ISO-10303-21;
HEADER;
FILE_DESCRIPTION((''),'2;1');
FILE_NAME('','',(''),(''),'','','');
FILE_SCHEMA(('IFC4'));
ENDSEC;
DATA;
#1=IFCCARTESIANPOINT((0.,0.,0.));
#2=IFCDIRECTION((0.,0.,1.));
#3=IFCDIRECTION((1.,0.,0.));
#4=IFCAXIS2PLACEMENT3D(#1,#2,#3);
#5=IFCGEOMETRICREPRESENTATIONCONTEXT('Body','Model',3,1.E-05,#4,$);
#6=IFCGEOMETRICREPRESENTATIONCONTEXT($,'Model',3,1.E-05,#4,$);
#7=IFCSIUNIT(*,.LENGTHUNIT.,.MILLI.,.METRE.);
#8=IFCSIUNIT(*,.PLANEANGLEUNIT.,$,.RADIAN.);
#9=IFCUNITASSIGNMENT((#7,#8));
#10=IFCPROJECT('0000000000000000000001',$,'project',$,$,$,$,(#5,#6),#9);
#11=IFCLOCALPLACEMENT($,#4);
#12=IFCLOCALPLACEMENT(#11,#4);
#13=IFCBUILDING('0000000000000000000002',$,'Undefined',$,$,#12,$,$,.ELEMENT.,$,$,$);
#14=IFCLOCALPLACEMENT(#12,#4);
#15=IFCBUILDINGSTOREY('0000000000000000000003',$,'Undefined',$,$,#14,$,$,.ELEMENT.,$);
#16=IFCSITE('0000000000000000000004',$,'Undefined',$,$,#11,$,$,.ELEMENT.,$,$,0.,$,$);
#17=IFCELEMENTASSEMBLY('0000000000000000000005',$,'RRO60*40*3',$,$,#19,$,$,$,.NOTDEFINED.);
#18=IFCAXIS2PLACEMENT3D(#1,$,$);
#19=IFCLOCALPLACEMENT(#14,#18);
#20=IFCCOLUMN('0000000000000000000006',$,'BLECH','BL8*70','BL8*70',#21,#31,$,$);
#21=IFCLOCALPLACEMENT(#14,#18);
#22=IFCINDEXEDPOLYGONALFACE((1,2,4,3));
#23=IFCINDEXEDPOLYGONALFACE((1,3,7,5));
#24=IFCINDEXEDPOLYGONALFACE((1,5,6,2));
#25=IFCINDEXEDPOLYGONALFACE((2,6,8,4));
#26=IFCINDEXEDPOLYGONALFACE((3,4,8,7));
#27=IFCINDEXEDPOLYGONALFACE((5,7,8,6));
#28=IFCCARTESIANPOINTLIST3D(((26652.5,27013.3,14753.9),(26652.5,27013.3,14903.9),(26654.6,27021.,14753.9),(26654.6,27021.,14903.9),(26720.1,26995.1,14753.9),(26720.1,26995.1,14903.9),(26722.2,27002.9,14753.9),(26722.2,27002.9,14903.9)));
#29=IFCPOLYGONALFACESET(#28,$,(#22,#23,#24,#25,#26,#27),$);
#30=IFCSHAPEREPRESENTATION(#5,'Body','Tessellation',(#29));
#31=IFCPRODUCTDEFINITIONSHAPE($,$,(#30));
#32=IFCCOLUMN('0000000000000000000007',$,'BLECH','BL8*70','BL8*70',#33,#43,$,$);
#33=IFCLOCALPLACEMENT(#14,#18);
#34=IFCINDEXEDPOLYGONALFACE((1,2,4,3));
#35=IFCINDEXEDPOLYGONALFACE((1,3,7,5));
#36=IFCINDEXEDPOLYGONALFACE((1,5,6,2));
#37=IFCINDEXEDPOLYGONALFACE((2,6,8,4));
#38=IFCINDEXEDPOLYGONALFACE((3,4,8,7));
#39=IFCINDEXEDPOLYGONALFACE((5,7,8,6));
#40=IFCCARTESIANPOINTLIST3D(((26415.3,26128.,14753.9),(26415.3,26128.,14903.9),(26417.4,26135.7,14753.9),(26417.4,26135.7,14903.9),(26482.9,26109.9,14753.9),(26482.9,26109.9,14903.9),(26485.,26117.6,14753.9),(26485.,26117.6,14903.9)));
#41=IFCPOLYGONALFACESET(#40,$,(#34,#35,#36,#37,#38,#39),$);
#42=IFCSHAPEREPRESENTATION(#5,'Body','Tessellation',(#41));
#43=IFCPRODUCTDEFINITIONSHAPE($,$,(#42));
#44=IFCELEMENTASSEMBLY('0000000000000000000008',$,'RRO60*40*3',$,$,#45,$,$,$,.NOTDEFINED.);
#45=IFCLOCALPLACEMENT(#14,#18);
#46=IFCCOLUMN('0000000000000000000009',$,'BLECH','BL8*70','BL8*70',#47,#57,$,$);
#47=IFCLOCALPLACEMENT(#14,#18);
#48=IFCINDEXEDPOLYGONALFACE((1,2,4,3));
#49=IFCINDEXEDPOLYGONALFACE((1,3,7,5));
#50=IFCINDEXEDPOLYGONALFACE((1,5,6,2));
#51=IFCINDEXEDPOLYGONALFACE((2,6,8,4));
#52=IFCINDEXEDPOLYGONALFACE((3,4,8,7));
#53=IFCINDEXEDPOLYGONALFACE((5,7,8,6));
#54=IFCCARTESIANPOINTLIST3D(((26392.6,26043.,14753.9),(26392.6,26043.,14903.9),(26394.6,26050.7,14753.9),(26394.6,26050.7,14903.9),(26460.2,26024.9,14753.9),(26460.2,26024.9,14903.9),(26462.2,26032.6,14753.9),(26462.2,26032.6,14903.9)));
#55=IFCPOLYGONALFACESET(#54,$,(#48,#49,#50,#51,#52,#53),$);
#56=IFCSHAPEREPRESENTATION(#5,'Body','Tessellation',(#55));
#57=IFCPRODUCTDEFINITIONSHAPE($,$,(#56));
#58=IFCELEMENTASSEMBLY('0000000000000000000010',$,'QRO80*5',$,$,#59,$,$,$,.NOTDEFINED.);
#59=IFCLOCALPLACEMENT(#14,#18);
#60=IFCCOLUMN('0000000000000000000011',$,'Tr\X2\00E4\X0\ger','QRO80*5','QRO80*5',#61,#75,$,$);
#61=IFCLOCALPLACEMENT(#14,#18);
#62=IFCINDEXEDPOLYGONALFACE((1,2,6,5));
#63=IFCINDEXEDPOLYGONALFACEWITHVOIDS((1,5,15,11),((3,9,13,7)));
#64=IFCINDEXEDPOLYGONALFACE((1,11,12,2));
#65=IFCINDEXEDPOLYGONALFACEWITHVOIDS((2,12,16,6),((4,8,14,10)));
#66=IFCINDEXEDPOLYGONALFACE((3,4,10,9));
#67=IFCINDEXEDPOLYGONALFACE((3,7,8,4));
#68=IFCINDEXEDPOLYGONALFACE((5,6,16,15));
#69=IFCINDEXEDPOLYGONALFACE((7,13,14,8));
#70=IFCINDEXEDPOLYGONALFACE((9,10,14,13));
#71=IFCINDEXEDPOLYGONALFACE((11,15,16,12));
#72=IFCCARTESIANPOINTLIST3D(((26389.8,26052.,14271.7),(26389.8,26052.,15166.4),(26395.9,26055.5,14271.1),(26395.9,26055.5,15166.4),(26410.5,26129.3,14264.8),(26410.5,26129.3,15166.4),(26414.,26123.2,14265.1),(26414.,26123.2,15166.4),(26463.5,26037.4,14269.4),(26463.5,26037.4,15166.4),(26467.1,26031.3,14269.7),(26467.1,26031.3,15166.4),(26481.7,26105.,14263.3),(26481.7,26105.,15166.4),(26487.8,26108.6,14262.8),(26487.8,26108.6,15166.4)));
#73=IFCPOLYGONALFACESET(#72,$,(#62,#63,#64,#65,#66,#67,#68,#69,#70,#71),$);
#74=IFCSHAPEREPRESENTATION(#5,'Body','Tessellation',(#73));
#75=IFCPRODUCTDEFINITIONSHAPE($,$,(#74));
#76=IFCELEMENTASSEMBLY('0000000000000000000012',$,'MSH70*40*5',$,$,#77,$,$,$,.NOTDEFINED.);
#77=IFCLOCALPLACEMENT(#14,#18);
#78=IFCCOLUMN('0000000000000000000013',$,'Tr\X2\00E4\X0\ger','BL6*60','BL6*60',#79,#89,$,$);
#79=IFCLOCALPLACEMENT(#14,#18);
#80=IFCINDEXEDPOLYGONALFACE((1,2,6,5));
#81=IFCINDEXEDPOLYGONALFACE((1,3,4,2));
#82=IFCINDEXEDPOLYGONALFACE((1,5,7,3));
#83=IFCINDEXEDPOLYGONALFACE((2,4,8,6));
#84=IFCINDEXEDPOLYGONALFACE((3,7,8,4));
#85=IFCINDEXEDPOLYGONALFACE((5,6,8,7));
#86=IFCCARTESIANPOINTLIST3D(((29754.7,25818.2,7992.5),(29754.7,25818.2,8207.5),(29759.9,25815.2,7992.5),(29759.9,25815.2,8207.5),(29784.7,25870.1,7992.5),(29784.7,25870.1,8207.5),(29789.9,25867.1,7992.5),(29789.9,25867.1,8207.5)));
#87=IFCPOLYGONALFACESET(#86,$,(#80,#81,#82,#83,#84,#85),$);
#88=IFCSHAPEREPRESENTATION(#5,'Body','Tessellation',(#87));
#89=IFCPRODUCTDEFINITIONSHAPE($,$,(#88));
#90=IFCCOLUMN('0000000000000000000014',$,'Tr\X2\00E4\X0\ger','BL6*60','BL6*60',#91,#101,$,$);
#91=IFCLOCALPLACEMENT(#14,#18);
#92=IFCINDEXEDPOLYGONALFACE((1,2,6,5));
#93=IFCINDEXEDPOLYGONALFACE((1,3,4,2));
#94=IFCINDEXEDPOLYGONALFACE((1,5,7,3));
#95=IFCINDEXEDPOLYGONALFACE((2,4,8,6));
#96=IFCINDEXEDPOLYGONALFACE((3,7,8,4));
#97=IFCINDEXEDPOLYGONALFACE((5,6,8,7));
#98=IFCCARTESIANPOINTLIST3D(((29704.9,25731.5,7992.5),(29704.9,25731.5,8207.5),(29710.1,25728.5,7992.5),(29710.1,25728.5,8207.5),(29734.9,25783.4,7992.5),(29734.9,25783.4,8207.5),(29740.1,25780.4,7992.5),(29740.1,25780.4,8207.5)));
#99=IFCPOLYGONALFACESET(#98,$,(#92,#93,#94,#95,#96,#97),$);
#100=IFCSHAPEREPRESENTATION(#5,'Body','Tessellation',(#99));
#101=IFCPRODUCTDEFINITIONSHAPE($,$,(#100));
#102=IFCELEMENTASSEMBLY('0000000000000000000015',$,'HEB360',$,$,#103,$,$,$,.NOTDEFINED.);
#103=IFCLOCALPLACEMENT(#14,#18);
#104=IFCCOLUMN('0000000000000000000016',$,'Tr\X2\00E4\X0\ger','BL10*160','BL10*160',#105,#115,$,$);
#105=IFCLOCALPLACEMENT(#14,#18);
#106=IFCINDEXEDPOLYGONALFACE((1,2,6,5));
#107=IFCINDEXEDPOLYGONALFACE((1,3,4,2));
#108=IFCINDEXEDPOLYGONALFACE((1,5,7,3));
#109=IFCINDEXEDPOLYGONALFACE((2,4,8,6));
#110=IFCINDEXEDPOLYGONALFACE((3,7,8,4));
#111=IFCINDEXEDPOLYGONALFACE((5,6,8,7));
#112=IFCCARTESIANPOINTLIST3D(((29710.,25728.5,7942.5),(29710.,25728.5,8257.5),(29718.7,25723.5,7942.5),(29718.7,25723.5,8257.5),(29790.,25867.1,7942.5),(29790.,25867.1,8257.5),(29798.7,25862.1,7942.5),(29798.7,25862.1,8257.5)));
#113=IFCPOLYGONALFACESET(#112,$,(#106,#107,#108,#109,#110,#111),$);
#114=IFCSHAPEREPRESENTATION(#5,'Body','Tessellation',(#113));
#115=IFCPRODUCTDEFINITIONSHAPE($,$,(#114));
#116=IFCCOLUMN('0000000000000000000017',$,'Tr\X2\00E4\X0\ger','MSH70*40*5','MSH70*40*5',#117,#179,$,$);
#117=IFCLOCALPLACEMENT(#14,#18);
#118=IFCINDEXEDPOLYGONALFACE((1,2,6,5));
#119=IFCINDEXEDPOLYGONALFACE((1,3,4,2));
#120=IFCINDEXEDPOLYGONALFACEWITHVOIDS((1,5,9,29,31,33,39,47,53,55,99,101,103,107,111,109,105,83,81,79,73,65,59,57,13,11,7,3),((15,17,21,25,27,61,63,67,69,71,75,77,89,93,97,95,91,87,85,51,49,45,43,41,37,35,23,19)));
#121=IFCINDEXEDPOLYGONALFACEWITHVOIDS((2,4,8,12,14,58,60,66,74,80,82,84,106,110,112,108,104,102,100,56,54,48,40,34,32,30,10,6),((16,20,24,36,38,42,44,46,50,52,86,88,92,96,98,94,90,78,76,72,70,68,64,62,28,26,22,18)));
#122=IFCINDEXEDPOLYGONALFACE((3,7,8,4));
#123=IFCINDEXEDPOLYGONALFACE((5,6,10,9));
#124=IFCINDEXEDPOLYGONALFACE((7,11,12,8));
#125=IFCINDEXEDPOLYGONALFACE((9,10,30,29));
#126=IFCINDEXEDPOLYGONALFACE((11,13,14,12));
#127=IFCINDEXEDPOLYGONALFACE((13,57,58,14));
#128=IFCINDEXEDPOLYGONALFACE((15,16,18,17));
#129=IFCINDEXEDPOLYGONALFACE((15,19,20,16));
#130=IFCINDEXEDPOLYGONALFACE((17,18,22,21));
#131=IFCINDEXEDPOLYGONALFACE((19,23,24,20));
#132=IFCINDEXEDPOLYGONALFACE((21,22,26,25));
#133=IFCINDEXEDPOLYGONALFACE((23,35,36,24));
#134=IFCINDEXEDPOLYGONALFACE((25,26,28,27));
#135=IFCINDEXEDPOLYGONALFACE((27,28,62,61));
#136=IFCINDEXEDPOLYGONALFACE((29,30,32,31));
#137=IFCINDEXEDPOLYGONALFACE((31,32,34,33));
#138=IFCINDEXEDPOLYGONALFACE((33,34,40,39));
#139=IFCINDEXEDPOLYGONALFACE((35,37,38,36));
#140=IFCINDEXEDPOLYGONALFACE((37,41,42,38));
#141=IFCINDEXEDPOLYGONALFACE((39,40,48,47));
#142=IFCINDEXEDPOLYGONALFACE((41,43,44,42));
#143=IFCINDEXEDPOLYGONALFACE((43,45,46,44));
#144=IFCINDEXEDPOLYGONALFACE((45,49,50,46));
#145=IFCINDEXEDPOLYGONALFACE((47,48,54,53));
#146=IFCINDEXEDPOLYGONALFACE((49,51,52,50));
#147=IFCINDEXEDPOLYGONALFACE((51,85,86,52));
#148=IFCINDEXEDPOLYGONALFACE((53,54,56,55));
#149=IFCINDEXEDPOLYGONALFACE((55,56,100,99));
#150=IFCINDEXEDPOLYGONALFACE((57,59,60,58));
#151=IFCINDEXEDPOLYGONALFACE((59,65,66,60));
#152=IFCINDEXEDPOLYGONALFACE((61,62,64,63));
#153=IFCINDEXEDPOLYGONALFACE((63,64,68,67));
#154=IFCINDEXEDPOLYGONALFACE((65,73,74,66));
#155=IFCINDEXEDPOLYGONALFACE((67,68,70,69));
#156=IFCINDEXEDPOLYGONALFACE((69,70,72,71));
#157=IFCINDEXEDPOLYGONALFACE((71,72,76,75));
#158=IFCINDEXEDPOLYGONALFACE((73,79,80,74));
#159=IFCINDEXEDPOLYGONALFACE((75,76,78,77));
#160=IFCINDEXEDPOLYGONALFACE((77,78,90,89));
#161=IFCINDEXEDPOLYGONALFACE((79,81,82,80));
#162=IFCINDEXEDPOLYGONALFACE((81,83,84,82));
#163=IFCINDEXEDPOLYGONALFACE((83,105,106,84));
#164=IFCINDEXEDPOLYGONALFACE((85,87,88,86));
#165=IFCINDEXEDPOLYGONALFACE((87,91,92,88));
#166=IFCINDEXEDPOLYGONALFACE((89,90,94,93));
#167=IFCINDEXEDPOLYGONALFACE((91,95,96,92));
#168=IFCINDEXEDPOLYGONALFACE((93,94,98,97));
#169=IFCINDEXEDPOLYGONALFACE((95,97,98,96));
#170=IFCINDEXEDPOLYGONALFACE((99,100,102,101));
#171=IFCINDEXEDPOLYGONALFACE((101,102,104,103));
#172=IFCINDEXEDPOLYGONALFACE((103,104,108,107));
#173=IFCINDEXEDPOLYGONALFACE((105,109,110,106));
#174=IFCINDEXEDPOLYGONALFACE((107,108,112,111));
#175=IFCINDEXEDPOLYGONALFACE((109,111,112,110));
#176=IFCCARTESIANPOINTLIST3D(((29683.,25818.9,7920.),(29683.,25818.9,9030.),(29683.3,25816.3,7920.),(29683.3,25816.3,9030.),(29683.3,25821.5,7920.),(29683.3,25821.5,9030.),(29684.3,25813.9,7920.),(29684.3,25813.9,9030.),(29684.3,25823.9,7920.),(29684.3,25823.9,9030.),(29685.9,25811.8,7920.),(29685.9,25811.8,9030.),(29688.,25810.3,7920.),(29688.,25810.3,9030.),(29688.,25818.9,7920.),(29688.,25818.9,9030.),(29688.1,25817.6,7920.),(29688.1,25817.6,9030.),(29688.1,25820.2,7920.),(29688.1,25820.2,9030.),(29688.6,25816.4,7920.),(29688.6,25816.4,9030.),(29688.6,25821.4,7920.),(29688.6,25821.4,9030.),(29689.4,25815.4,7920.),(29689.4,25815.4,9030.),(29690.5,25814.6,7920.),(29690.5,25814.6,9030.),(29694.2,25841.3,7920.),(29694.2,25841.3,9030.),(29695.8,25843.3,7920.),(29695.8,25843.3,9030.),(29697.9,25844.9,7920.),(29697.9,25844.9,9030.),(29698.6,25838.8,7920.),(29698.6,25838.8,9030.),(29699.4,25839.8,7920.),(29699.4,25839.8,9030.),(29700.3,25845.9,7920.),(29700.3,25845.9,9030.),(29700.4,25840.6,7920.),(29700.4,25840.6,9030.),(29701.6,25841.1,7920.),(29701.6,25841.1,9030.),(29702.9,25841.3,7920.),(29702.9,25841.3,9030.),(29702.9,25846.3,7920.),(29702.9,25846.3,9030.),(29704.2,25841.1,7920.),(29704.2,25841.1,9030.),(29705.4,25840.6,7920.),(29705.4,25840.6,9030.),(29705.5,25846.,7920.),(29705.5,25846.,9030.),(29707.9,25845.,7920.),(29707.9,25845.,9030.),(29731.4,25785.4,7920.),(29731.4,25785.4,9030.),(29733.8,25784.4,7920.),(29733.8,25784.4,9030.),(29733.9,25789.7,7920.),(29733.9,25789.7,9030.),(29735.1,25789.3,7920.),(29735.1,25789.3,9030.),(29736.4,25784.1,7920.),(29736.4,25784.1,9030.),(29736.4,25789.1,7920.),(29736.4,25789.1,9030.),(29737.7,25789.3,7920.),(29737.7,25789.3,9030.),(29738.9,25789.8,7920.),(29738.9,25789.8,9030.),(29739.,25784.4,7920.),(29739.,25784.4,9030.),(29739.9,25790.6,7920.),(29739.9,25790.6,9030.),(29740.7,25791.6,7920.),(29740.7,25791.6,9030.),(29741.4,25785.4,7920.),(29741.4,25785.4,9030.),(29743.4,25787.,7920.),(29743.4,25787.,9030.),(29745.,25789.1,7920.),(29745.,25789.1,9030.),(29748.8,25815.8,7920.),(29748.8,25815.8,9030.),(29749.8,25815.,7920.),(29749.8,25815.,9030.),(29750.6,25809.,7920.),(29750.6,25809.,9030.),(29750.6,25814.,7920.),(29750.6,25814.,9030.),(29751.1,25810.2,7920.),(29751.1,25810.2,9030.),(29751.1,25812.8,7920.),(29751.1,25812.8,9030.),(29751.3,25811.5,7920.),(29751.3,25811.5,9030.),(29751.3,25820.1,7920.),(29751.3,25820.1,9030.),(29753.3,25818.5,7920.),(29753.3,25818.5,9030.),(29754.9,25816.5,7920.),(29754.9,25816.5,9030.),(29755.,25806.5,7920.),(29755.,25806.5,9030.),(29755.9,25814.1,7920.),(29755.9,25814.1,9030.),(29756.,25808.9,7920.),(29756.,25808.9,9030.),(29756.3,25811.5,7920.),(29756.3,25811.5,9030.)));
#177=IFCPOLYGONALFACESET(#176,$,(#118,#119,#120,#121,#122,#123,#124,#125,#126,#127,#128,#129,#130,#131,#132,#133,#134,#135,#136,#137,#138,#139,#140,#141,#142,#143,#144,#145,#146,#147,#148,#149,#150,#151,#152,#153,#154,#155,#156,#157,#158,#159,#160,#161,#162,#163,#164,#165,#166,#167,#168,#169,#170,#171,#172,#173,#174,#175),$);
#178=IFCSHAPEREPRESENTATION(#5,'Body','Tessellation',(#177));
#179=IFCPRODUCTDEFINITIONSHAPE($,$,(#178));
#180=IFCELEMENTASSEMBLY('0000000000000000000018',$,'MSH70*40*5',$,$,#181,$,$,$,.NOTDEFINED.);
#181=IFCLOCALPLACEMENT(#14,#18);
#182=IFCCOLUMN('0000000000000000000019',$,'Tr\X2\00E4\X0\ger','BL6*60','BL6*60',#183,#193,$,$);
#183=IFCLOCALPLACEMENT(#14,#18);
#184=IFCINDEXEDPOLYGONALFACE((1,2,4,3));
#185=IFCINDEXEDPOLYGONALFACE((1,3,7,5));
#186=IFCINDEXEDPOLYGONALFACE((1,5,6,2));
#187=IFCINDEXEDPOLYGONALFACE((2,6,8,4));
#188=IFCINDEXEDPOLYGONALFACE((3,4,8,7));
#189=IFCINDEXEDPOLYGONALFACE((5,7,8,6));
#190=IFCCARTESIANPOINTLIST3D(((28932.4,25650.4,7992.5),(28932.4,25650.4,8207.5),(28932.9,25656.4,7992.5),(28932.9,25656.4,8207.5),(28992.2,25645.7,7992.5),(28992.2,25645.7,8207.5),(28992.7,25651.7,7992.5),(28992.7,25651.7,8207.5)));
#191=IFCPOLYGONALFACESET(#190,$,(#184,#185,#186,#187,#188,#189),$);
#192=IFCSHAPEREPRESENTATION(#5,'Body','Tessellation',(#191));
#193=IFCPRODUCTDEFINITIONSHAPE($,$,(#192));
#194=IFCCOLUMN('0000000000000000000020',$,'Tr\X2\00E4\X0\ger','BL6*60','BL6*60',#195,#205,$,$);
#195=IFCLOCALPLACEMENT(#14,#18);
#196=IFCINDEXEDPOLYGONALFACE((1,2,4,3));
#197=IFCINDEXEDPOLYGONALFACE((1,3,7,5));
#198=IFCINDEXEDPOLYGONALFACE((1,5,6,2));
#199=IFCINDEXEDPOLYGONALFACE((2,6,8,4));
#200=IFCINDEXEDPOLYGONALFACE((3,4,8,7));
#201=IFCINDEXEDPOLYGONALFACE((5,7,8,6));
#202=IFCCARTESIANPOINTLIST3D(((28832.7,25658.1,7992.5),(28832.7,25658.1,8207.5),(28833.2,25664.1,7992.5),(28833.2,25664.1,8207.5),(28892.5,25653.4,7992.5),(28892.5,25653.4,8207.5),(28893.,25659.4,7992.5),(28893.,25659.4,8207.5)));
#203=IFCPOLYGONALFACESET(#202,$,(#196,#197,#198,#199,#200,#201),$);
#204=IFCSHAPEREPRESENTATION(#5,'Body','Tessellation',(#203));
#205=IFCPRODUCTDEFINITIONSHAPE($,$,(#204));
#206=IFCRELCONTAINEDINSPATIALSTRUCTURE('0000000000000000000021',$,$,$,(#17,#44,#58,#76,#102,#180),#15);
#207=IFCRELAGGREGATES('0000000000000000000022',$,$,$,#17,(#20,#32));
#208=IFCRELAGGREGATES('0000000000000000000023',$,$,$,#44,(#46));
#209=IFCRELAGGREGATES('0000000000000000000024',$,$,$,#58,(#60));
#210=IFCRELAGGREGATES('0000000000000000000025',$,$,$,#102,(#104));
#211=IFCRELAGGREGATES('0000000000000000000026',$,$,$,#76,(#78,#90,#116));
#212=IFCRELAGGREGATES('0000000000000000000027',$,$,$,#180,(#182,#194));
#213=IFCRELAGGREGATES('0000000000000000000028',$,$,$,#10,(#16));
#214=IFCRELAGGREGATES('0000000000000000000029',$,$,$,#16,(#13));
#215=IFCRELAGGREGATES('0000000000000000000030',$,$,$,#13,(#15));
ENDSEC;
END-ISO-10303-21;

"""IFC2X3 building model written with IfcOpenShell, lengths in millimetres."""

from ifc_helpers import new_model, si_unit, frame, origin_with_axes, origin_2d_with_axis, place, context, project, spatial, rectangle, hollow_rectangle, extrude, clip, halfspace, element, aggregate, save


model = new_model("IFC2X3")

# Units and contexts
model_context_1 = context("Model", 3, precision=1e-05, world=origin_with_axes(), identifier="Body")
model_context_2 = context("Model", 3, precision=1e-05, world=origin_with_axes())
ifc_project = project(units=[si_unit("LENGTHUNIT", "METRE", prefix="MILLI"), si_unit("PLANEANGLEUNIT", "RADIAN")], contexts=[model_context_1, model_context_2])

# Site, building, storey
site_placement = place(None, origin_with_axes())
site = spatial("IfcSite", under=ifc_project, at=site_placement, Name="Undefined", CompositionType="ELEMENT", RefElevation=0.0)
building_placement = place(site_placement, origin_with_axes())
building = spatial("IfcBuilding", under=site, at=building_placement, Name="Undefined", CompositionType="ELEMENT")
storey_placement = place(building_placement, origin_with_axes())
storey = spatial("IfcBuildingStorey", under=building, at=storey_placement, Name="Undefined", CompositionType="ELEMENT")

# Element assembly, columns
assembly_1 = element("IfcElementAssembly", 1, inside=storey, Name="RRO60*40*3", PredefinedType="NOTDEFINED")
column_1_placement = place(storey_placement, frame((26687.4, 27008.1, 14753.9), z_axis=(0.0, 0.0, 1.0), x_axis=(1.0, 0.0, 0.0)))
column_1 = element("IfcColumn", 2, at=column_1_placement, Name="BLECH", Description="BL8*70", ObjectType="BL8*70", context=model_context_1, shape_type="SweptSolid", body=[
    extrude(rectangle(XDim=8.0, YDim=70.0, at=origin_2d_with_axis()), frame((0.0, 0.0, 150.0), z_axis=(0.0, 0.0, -1.0), x_axis=(-0.258815, -0.965927, -0.000003)), (0.0, 0.0, 1.0), 150.0),
])
column_2_placement = place(storey_placement, frame((26450.2, 26122.8, 14753.9), z_axis=(0.0, 0.0, 1.0), x_axis=(1.0, 0.0, 0.0)))
column_2 = element("IfcColumn", 3, at=column_2_placement, Name="BLECH", Description="BL8*70", ObjectType="BL8*70", context=model_context_1, shape_type="SweptSolid", body=[
    extrude(rectangle(XDim=8.0, YDim=70.0, at=origin_2d_with_axis()), frame((0.0, 0.0, 150.0), z_axis=(0.0, 0.0, -1.0), x_axis=(0.258815, 0.965927, 0.000003)), (0.0, 0.0, 1.0), 150.0),
])
aggregate(assembly_1, [column_1, column_2])

# Element assemblies, columns
assembly_2 = element("IfcElementAssembly", 4, inside=storey, Name="RRO60*40*3", PredefinedType="NOTDEFINED")
column_3_placement = place(storey_placement, frame((26427.4, 26037.8, 14753.9), z_axis=(0.0, 0.0, 1.0), x_axis=(1.0, 0.0, 0.0)))
column_3 = element("IfcColumn", 5, at=column_3_placement, Name="BLECH", Description="BL8*70", ObjectType="BL8*70", context=model_context_1, shape_type="SweptSolid", body=[
    extrude(rectangle(XDim=8.0, YDim=70.0, at=origin_2d_with_axis()), frame((0.0, 0.0, 150.0), z_axis=(0.0, 0.0, -1.0), x_axis=(-0.258815, -0.965927, -0.000003)), (0.0, 0.0, 1.0), 150.0),
])
aggregate(assembly_2, [column_3])
assembly_3 = element("IfcElementAssembly", 6, inside=storey, Name="QRO80*5", PredefinedType="NOTDEFINED")
column_4_placement = place(storey_placement, frame((26438.8, 26080.3, 14404.4), z_axis=(0.0, 0.0, 1.0), x_axis=(1.0, 0.0, 0.0)))
column_4 = element("IfcColumn", 7, at=column_4_placement, Name="Träger", Description="QRO80*5", ObjectType="QRO80*5", context=model_context_1, shape_type="Clipping", body=[
    clip(clip(extrude(hollow_rectangle(XDim=80.0, YDim=80.0, WallThickness=5.0, at=origin_2d_with_axis()), frame((0.0, 0.0, 762.0), z_axis=(0.0, 0.0, -1.0), x_axis=(-0.258926, -0.965897, -0.000005)), (0.0, 0.0, 1.0), 903.6), halfspace(frame((38.6, -10.4, -138.1), z_axis=(0.046071, 0.076365, 0.996015), x_axis=(-0.255919, -0.962895, 0.085663)), True)), halfspace(frame((-38.6, 10.4, 762.0), z_axis=(0.0, 0.0, -1.0), x_axis=(-0.258815, -0.965927, -0.000003)), True)),
])
aggregate(assembly_3, [column_4])

# Element assembly, columns
assembly_4 = element("IfcElementAssembly", 8, inside=storey, Name="MSH70*40*5", PredefinedType="NOTDEFINED")
column_5_placement = place(storey_placement, frame((29772.3, 25842.6, 7992.5), z_axis=(0.0, 0.0, 1.0), x_axis=(1.0, 0.0, 0.0)))
column_5 = element("IfcColumn", 9, at=column_5_placement, Name="Träger", Description="BL6*60", ObjectType="BL6*60", context=model_context_1, shape_type="SweptSolid", body=[
    extrude(rectangle(XDim=6.0, YDim=60.0, at=origin_2d_with_axis()), frame((0.0, 0.0, 215.0), z_axis=(0.0, 0.0, -1.0), x_axis=(-0.866025, 0.500001, 0.0)), (0.0, 0.0, 1.0), 215.0),
])
column_6_placement = place(storey_placement, frame((29722.5, 25756.0, 7992.5), z_axis=(0.0, 0.0, 1.0), x_axis=(1.0, 0.0, 0.0)))
column_6 = element("IfcColumn", 10, at=column_6_placement, Name="Träger", Description="BL6*60", ObjectType="BL6*60", context=model_context_1, shape_type="SweptSolid", body=[
    extrude(rectangle(XDim=6.0, YDim=60.0, at=origin_2d_with_axis()), frame((0.0, 0.0, 215.0), z_axis=(0.0, 0.0, -1.0), x_axis=(-0.866025, 0.500001, 0.0)), (0.0, 0.0, 1.0), 215.0),
])

# Element assembly, column
assembly_5 = element("IfcElementAssembly", 11, inside=storey, Name="HEB360", PredefinedType="NOTDEFINED")
column_7_placement = place(storey_placement, frame((29754.3, 25795.3, 7942.5), z_axis=(0.0, 0.0, 1.0), x_axis=(1.0, 0.0, 0.0)))
column_7 = element("IfcColumn", 12, at=column_7_placement, Name="Träger", Description="BL10*160", ObjectType="BL10*160", context=model_context_1, shape_type="SweptSolid", body=[
    extrude(rectangle(XDim=10.0, YDim=160.0, at=origin_2d_with_axis()), frame((0.0, 0.0, 315.0), z_axis=(0.0, 0.0, -1.0), x_axis=(-0.866025, 0.500001, 0.0)), (0.0, 0.0, 1.0), 315.0),
])
aggregate(assembly_5, [column_7])

# Column
column_8_placement = place(storey_placement, frame((29719.6, 25815.2, 7920.0), z_axis=(0.0, 0.0, 1.0), x_axis=(1.0, 0.0, 0.0)))
column_8 = element("IfcColumn", 13, at=column_8_placement, Name="Träger", Description="MSH70*40*5", ObjectType="MSH70*40*5", context=model_context_1, shape_type="SweptSolid", body=[
    extrude(hollow_rectangle(XDim=40.0, YDim=70.0, WallThickness=5.0, InnerFilletRadius=5.0, OuterFilletRadius=10.0, at=origin_2d_with_axis()), frame((0.0, 0.0, 1110.0), z_axis=(0.0, 0.0, -1.0), x_axis=(0.496974, 0.867765, 0.000005)), (0.0, 0.0, 1.0), 1110.0),
])
aggregate(assembly_4, [column_5, column_6, column_8])

# Element assembly, columns
assembly_6 = element("IfcElementAssembly", 14, inside=storey, Name="MSH70*40*5", PredefinedType="NOTDEFINED")
column_9_placement = place(storey_placement, frame((28962.5, 25651.1, 7992.5), z_axis=(0.0, 0.0, 1.0), x_axis=(1.0, 0.0, 0.0)))
column_9 = element("IfcColumn", 15, at=column_9_placement, Name="Träger", Description="BL6*60", ObjectType="BL6*60", context=model_context_1, shape_type="SweptSolid", body=[
    extrude(rectangle(XDim=6.0, YDim=60.0, at=origin_2d_with_axis()), frame((0.0, 0.0, 215.0), z_axis=(0.0, 0.0, -1.0), x_axis=(0.078459, 0.996917, 0.0)), (0.0, 0.0, 1.0), 215.0),
])
column_10_placement = place(storey_placement, frame((28862.8, 25658.8, 7992.5), z_axis=(0.0, 0.0, 1.0), x_axis=(1.0, 0.0, 0.0)))
column_10 = element("IfcColumn", 16, at=column_10_placement, Name="Träger", Description="BL6*60", ObjectType="BL6*60", context=model_context_1, shape_type="SweptSolid", body=[
    extrude(rectangle(XDim=6.0, YDim=60.0, at=origin_2d_with_axis()), frame((0.0, 0.0, 215.0), z_axis=(0.0, 0.0, -1.0), x_axis=(0.078459, 0.996917, 0.0)), (0.0, 0.0, 1.0), 215.0),
])

aggregate(assembly_6, [column_9, column_10])

save(model, "model.ifc")
